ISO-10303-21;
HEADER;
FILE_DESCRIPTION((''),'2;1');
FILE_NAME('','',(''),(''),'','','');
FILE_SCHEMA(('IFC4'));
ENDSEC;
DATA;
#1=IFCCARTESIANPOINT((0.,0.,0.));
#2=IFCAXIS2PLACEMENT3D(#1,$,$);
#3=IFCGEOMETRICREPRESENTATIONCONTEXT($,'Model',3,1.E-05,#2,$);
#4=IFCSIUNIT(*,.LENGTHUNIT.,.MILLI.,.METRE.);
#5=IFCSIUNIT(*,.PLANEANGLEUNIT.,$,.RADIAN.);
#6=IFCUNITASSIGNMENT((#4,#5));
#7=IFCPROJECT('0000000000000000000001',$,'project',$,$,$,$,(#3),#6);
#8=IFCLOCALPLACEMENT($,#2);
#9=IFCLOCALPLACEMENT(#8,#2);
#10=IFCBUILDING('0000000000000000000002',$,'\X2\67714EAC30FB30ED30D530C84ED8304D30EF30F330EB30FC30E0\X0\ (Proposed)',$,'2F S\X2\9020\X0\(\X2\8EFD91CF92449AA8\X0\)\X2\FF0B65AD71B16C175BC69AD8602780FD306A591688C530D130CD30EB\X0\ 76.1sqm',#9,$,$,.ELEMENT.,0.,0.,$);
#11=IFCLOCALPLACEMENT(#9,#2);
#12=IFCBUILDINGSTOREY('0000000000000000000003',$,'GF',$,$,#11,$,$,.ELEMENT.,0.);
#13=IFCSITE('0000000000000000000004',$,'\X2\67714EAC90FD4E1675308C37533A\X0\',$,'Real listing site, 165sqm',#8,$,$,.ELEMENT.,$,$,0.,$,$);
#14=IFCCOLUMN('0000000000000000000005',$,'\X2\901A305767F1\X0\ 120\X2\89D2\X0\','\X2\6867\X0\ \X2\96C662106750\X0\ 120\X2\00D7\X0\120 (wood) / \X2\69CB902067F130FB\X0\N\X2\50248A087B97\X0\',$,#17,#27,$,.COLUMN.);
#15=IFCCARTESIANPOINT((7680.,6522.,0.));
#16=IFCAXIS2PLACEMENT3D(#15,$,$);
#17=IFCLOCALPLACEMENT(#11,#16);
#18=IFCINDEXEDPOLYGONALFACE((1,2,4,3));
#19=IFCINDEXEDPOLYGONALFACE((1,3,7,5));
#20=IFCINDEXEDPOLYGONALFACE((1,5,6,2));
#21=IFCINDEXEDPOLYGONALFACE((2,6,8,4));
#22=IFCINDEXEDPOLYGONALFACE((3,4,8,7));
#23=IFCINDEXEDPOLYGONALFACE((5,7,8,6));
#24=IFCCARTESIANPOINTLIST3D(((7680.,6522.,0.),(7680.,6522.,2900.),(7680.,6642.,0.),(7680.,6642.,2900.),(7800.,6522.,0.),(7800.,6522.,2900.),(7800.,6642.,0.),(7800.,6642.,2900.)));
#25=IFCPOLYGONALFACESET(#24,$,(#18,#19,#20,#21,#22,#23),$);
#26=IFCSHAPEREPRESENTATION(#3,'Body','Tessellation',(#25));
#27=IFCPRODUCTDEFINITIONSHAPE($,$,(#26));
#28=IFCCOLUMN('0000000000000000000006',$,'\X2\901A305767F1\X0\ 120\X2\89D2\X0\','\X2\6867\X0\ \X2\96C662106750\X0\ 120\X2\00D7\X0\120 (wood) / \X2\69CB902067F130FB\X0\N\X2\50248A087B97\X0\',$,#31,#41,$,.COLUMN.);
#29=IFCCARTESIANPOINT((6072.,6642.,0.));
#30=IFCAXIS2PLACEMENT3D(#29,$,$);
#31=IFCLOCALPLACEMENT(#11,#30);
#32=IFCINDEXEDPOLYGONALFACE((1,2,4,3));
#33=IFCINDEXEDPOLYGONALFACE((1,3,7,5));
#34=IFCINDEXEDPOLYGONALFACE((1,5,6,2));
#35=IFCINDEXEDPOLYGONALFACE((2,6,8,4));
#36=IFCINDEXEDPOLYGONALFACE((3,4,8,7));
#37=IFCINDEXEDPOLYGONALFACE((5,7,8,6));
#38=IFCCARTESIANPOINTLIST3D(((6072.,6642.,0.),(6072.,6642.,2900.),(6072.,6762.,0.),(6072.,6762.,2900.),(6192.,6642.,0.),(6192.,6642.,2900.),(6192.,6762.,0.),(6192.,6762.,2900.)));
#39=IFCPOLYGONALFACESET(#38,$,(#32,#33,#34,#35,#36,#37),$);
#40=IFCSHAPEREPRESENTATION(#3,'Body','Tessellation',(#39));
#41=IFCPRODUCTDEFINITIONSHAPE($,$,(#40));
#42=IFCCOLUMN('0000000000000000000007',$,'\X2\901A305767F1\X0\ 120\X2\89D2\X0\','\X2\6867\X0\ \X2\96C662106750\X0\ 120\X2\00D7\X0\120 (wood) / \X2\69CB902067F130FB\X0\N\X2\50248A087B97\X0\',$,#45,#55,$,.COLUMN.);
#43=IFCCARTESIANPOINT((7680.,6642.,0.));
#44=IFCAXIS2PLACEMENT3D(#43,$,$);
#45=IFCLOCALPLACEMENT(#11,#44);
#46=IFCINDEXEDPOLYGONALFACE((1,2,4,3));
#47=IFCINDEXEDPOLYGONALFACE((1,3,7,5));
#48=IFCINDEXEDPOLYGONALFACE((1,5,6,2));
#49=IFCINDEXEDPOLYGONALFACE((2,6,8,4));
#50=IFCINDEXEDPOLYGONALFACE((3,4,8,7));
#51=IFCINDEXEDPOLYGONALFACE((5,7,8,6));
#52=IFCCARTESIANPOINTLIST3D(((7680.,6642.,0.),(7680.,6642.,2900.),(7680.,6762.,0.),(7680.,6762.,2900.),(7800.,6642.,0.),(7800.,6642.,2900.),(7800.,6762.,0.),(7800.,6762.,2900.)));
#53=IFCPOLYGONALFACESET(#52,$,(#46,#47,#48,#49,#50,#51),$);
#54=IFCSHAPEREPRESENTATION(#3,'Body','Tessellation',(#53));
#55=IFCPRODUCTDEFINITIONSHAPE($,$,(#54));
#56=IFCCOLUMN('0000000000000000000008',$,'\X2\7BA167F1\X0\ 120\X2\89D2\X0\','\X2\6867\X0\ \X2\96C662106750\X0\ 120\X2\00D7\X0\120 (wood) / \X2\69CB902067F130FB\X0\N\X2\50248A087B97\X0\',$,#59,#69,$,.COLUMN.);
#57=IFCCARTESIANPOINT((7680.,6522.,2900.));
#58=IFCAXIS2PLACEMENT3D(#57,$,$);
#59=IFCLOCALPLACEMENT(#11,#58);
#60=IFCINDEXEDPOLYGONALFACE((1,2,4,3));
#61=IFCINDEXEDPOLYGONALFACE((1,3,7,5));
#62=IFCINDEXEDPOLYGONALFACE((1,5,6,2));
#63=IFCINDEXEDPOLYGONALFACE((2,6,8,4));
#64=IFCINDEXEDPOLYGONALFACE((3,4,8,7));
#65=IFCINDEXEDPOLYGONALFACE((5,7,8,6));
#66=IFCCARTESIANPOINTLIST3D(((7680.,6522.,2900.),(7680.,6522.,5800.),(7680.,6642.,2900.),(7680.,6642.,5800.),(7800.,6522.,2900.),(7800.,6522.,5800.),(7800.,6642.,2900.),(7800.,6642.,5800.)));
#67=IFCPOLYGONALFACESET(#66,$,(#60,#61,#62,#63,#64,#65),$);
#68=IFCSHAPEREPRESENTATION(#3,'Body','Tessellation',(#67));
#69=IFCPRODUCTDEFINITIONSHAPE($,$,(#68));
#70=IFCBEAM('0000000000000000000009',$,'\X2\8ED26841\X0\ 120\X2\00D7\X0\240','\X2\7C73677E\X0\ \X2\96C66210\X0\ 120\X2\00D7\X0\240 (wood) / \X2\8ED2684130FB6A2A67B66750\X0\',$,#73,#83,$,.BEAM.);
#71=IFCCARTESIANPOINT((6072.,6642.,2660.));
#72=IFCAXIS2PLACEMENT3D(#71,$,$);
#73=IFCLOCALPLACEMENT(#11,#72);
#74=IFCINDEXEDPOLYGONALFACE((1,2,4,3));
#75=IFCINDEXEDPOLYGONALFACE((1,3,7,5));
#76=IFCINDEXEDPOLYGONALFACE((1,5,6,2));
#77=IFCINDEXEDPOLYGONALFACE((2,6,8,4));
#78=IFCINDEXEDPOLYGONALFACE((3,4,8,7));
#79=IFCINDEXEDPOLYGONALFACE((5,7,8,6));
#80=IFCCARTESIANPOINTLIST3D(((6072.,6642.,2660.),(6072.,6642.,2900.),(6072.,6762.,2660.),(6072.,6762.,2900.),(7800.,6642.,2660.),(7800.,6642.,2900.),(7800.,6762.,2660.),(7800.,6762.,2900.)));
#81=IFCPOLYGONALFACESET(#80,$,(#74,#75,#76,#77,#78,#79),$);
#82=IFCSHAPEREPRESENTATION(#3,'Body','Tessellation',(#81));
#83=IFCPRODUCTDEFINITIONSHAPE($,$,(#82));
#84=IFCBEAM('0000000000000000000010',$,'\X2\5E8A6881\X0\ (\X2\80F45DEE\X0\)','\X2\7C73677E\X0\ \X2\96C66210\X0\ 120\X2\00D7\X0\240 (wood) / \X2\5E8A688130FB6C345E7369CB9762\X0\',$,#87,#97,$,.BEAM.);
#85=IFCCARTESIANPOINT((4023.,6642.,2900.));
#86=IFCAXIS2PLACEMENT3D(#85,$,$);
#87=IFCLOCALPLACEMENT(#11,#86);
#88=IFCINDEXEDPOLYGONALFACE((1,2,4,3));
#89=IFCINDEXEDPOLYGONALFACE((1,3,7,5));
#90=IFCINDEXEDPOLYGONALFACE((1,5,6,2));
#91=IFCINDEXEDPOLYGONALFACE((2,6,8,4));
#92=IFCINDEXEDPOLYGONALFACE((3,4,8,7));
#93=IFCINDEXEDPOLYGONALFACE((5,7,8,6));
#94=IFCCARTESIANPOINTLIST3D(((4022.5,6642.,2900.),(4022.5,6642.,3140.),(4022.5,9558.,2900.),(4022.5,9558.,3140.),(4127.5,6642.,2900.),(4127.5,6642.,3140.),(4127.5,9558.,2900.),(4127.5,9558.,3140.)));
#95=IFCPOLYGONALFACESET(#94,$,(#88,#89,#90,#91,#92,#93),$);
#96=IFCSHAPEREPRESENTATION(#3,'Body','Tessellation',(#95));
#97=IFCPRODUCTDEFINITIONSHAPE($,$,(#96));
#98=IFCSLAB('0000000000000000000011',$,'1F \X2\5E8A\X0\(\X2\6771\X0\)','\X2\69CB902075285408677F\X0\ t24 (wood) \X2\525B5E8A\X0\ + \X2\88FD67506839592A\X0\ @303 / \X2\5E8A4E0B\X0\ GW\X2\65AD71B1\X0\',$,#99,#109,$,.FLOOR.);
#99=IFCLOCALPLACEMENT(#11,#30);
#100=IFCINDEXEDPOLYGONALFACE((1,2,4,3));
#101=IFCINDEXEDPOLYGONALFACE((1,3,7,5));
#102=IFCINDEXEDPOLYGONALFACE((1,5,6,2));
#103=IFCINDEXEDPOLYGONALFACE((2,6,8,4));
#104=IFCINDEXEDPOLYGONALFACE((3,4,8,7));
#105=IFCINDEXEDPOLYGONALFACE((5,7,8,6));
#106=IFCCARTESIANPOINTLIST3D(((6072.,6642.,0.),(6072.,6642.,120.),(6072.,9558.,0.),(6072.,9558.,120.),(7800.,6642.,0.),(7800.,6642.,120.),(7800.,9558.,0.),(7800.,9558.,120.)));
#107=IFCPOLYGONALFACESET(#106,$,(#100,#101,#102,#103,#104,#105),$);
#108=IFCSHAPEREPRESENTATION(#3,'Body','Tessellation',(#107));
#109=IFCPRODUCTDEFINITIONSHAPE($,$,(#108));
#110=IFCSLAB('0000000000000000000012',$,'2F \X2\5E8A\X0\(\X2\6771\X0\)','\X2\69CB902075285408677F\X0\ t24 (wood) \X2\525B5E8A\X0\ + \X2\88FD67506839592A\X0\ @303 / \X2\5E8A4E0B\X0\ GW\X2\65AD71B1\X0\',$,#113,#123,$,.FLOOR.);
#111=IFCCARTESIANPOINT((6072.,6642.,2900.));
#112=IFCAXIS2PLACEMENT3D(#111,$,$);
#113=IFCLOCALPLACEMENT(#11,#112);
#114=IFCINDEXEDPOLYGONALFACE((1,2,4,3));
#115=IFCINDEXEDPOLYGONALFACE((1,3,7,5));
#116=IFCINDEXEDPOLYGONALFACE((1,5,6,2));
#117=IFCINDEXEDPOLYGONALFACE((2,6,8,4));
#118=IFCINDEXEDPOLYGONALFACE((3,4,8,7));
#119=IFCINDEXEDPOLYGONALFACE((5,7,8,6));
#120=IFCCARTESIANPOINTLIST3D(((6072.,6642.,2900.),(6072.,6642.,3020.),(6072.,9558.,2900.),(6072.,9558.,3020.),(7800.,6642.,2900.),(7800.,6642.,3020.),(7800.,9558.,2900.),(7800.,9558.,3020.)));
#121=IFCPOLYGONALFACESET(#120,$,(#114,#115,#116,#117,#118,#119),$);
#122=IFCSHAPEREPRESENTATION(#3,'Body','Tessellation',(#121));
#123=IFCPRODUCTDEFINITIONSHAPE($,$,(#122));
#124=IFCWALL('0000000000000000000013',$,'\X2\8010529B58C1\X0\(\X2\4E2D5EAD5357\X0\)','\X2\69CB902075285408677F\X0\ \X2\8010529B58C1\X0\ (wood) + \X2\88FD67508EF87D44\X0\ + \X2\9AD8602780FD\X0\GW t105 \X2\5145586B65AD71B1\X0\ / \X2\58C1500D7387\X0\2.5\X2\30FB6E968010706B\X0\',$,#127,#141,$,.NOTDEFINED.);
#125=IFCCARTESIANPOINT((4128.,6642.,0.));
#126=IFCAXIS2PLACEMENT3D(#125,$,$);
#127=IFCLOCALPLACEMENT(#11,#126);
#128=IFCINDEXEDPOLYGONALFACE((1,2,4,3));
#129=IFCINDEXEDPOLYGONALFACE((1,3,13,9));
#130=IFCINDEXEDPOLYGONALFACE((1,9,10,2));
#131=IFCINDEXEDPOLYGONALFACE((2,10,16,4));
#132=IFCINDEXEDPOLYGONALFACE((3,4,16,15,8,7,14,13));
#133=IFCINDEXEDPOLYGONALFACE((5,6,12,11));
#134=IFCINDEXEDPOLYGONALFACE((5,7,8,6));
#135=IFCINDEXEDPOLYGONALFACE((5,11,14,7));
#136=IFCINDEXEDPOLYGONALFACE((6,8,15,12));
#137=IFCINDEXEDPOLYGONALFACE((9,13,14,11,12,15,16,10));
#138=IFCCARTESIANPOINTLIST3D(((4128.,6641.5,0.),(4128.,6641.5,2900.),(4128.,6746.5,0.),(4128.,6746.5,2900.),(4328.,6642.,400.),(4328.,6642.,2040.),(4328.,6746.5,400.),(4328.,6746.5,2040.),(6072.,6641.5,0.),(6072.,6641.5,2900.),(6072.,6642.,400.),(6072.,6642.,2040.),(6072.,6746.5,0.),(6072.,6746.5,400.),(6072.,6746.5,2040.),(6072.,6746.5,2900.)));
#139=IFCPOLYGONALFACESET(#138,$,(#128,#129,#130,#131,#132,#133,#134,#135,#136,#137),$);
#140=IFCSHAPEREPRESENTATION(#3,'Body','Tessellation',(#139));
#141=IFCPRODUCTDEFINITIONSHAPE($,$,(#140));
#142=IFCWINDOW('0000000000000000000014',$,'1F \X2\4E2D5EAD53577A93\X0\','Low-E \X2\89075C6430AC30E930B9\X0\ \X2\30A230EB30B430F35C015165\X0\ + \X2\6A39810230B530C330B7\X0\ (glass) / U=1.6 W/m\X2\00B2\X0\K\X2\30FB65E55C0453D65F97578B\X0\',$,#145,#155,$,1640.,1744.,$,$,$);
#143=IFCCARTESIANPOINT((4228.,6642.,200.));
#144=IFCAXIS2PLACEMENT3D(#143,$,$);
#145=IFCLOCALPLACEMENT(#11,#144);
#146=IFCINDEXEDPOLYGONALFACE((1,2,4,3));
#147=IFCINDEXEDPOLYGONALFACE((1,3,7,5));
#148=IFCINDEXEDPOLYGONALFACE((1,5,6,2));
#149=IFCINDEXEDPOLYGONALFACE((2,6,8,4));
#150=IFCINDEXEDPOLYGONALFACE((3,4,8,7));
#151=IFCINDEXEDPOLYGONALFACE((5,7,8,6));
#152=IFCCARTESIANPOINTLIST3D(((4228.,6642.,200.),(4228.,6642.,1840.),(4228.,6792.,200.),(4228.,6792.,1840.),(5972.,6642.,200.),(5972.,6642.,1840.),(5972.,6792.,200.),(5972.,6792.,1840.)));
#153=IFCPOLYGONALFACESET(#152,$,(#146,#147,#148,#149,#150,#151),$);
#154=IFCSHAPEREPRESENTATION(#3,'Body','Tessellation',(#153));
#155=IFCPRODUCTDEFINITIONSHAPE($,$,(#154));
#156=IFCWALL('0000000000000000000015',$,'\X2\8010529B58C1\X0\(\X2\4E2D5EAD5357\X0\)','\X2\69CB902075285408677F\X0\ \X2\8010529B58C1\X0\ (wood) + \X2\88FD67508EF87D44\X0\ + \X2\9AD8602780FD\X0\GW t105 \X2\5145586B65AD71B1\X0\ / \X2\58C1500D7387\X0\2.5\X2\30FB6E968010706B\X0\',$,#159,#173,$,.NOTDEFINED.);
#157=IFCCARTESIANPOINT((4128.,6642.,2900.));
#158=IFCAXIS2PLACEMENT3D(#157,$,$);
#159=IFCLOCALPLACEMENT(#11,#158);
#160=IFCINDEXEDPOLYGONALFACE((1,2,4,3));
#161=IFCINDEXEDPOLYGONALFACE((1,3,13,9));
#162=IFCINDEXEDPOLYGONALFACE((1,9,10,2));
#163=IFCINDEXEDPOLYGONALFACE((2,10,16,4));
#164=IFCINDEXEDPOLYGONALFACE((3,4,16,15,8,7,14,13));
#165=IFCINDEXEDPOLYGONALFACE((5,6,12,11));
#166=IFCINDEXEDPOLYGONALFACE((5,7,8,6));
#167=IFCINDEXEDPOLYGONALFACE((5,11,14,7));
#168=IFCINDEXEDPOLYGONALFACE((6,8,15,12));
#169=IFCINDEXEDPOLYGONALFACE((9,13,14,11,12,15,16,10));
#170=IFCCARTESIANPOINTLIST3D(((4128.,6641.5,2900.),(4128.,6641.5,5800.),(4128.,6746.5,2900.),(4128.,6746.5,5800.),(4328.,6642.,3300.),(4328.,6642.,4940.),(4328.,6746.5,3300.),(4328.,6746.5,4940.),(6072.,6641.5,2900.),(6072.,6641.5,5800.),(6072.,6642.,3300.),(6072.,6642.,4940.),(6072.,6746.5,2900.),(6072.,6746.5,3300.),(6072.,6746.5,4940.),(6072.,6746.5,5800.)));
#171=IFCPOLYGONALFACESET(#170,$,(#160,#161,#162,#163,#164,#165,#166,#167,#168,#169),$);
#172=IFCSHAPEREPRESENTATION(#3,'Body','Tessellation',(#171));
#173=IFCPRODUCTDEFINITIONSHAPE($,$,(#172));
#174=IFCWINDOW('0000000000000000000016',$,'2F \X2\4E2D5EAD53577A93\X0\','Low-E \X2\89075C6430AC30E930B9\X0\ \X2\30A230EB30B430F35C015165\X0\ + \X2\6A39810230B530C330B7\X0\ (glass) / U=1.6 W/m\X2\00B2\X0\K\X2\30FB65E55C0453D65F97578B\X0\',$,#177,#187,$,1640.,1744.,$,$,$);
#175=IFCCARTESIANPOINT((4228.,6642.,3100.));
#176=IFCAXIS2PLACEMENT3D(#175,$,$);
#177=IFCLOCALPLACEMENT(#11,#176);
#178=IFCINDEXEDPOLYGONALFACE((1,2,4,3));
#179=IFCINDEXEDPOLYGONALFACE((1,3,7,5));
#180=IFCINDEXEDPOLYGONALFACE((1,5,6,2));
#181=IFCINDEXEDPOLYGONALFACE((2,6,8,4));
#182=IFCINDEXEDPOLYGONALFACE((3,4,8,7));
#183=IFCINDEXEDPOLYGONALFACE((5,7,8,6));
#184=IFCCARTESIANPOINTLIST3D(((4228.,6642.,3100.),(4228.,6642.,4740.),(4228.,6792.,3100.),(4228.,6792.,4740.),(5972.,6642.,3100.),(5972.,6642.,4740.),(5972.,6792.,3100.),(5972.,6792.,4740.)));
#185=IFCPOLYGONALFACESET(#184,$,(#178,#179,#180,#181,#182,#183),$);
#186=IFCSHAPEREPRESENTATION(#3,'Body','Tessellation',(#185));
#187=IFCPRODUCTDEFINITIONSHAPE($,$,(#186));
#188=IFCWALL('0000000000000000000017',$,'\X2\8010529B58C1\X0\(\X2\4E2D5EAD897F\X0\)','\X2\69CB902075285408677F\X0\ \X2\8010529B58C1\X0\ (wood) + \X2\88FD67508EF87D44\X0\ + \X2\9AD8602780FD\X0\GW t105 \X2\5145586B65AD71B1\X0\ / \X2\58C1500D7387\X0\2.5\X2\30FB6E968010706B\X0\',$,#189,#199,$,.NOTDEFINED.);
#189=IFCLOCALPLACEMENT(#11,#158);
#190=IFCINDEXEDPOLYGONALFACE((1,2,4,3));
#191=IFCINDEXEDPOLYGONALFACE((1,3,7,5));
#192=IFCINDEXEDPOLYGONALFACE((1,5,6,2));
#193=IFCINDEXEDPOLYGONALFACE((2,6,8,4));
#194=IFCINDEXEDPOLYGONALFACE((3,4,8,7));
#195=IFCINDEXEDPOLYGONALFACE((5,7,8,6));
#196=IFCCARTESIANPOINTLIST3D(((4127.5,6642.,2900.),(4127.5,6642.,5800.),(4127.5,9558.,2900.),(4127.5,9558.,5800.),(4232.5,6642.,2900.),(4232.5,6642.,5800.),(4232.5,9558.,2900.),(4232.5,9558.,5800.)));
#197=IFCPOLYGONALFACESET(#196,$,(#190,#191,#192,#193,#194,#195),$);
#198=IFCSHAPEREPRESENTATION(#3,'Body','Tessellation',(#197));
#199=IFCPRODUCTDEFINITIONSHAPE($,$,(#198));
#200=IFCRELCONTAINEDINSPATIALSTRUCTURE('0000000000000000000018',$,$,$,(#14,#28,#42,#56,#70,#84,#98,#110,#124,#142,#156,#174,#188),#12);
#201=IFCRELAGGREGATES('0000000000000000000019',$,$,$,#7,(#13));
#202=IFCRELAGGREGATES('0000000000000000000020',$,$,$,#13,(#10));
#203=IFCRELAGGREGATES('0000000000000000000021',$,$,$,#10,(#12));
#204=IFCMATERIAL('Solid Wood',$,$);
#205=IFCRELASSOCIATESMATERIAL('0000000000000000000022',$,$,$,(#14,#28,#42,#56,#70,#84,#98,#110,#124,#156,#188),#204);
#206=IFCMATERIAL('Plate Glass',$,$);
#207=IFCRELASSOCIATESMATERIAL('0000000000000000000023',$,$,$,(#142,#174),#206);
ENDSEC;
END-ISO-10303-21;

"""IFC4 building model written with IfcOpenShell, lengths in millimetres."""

from ifc_helpers import new_model, si_unit, frame, frame_2d, origin, place, context, project, spatial, rectangle, extrude, material, element, fill, save


model = new_model("IFC4")

# Units and contexts
model_context = context("Model", 3, precision=1e-05, world=origin())
ifc_project = project(units=[si_unit("LENGTHUNIT", "METRE", prefix="MILLI"), si_unit("PLANEANGLEUNIT", "RADIAN")], contexts=[model_context])

# Site, building, storey
site_placement = place(None, origin())
site = spatial("IfcSite", under=ifc_project, at=site_placement, Name="東京都世田谷区", ObjectType="Real listing site, 165sqm", CompositionType="ELEMENT", RefElevation=0.0)
building_placement = place(site_placement, origin())
building = spatial("IfcBuilding", under=site, at=building_placement, Name="東京・ロフト付きワンルーム (Proposed)", ObjectType="2F S造(軽量鉄骨)＋断熱気密高性能な外装パネル 76.1sqm", CompositionType="ELEMENT", ElevationOfRefHeight=0.0, ElevationOfTerrain=0.0)
storey_placement = place(building_placement, origin())
storey = spatial("IfcBuildingStorey", under=building, at=storey_placement, Name="GF", CompositionType="ELEMENT", Elevation=0.0)

# Columns
ifc_material_1 = material(Name="Solid Wood")
column_1_placement = place(storey_placement, frame((7680.0, 6522.0, 0.0)))
element("IfcColumn", 1, at=column_1_placement, inside=storey, material=ifc_material_1, Name="通し柱 120角", Description="桧 集成材 120×120 (wood) / 構造柱・N値計算", PredefinedType="COLUMN", context=model_context, shape_type="SweptSolid", body=[
    extrude(rectangle(XDim=120.0, YDim=120.0, at=frame_2d((60.0, 60.0))), frame((7680.0, 6522.0, 0.0)), (0.0, 0.0, 1.0), 2900.0),
])
column_2_placement = place(storey_placement, frame((6072.0, 6642.0, 0.0)))
element("IfcColumn", 2, at=column_2_placement, inside=storey, material=ifc_material_1, Name="通し柱 120角", Description="桧 集成材 120×120 (wood) / 構造柱・N値計算", PredefinedType="COLUMN", context=model_context, shape_type="SweptSolid", body=[
    extrude(rectangle(XDim=120.0, YDim=120.0, at=frame_2d((60.0, 60.0))), frame((6072.0, 6642.0, 0.0)), (0.0, 0.0, 1.0), 2900.0),
])
column_3_placement = place(storey_placement, frame((7680.0, 6642.0, 0.0)))
element("IfcColumn", 3, at=column_3_placement, inside=storey, material=ifc_material_1, Name="通し柱 120角", Description="桧 集成材 120×120 (wood) / 構造柱・N値計算", PredefinedType="COLUMN", context=model_context, shape_type="SweptSolid", body=[
    extrude(rectangle(XDim=120.0, YDim=120.0, at=frame_2d((60.0, 60.0))), frame((7680.0, 6642.0, 0.0)), (0.0, 0.0, 1.0), 2900.0),
])
column_4_placement = place(storey_placement, frame((7680.0, 6522.0, 2900.0)))
element("IfcColumn", 4, at=column_4_placement, inside=storey, material=ifc_material_1, Name="管柱 120角", Description="桧 集成材 120×120 (wood) / 構造柱・N値計算", PredefinedType="COLUMN", context=model_context, shape_type="SweptSolid", body=[
    extrude(rectangle(XDim=120.0, YDim=120.0, at=frame_2d((60.0, 60.0))), frame((7680.0, 6522.0, 2900.0)), (0.0, 0.0, 1.0), 2900.0),
])

# Beams
beam_1_placement = place(storey_placement, frame((6072.0, 6642.0, 2660.0)))
element("IfcBeam", 5, at=beam_1_placement, inside=storey, material=ifc_material_1, Name="軒桁 120×240", Description="米松 集成 120×240 (wood) / 軒桁・横架材", PredefinedType="BEAM", context=model_context, shape_type="SweptSolid", body=[
    extrude(rectangle(XDim=1728.0, YDim=120.0, at=frame_2d((864.0, 60.0))), frame((6072.0, 6642.0, 2660.0)), (0.0, 0.0, 1.0), 240.0),
])
beam_2_placement = place(storey_placement, frame((4023.0, 6642.0, 2900.0)))
element("IfcBeam", 6, at=beam_2_placement, inside=storey, material=ifc_material_1, Name="床梁 (胴差)", Description="米松 集成 120×240 (wood) / 床梁・水平構面", PredefinedType="BEAM", context=model_context, shape_type="SweptSolid", body=[
    extrude(rectangle(XDim=105.0, YDim=2916.0, at=frame_2d((52.0, 1458.0))), frame((4023.0, 6642.0, 2900.0)), (0.0, 0.0, 1.0), 240.0),
])

# Slabs
slab_1_placement = place(storey_placement, frame((6072.0, 6642.0, 0.0)))
element("IfcSlab", 7, at=slab_1_placement, inside=storey, material=ifc_material_1, Name="1F 床(東)", Description="構造用合板 t24 (wood) 剛床 + 製材根太 @303 / 床下 GW断熱", PredefinedType="FLOOR", context=model_context, shape_type="SweptSolid", body=[
    extrude(rectangle(XDim=1728.0, YDim=2916.0, at=frame_2d((864.0, 1458.0))), frame((6072.0, 6642.0, 0.0)), (0.0, 0.0, 1.0), 120.0),
])
slab_2_placement = place(storey_placement, frame((6072.0, 6642.0, 2900.0)))
element("IfcSlab", 8, at=slab_2_placement, inside=storey, material=ifc_material_1, Name="2F 床(東)", Description="構造用合板 t24 (wood) 剛床 + 製材根太 @303 / 床下 GW断熱", PredefinedType="FLOOR", context=model_context, shape_type="SweptSolid", body=[
    extrude(rectangle(XDim=1728.0, YDim=2916.0, at=frame_2d((864.0, 1458.0))), frame((6072.0, 6642.0, 2900.0)), (0.0, 0.0, 1.0), 120.0),
])

# Wall, opening, window
wall_1_placement = place(storey_placement, frame((4128.0, 6642.0, 0.0)))
wall_1 = element("IfcWall", 9, at=wall_1_placement, inside=storey, material=ifc_material_1, Name="耐力壁(中庭南)", Description="構造用合板 耐力壁 (wood) + 製材軸組 + 高性能GW t105 充填断熱 / 壁倍率2.5・準耐火", PredefinedType="NOTDEFINED", context=model_context, shape_type="SweptSolid", body=[
    extrude(rectangle(XDim=1944.0, YDim=105.0, at=frame_2d((972.0, 52.0))), frame((4128.0, 6642.0, 0.0)), (0.0, 0.0, 1.0), 2900.0),
])
opening_1_placement = place(storey_placement, frame((4228.0, 6642.0, 200.0)))
opening_1 = element("IfcOpeningElement", 10, at=opening_1_placement, cuts=wall_1, PredefinedType="NOTDEFINED", context=model_context, shape_type="SweptSolid", body=[
    extrude(rectangle(XDim=1744.0, YDim=150.0, at=frame_2d((872.0, 75.0))), frame((4228.0, 6642.0, 200.0)), (0.0, 0.0, 1.0), 1640.0),
])
ifc_material_2 = material(Name="Plate Glass")
window_1_placement = place(storey_placement, frame((4228.0, 6642.0, 200.0)))
window_1 = element("IfcWindow", 11, at=window_1_placement, inside=storey, material=ifc_material_2, Name="1F 中庭南窓", Description="Low-E 複層ガラス アルゴン封入 + 樹脂サッシ (glass) / U=1.6 W/m²K・日射取得型", OverallHeight=1640.0, OverallWidth=1744.0, context=model_context, shape_type="SweptSolid", body=[
    extrude(rectangle(XDim=1744.0, YDim=150.0, at=frame_2d((872.0, 75.0))), frame((4228.0, 6642.0, 200.0)), (0.0, 0.0, 1.0), 1640.0),
])
fill(opening_1, window_1)

# Wall, opening, window
wall_2_placement = place(storey_placement, frame((4128.0, 6642.0, 2900.0)))
wall_2 = element("IfcWall", 12, at=wall_2_placement, inside=storey, material=ifc_material_1, Name="耐力壁(中庭南)", Description="構造用合板 耐力壁 (wood) + 製材軸組 + 高性能GW t105 充填断熱 / 壁倍率2.5・準耐火", PredefinedType="NOTDEFINED", context=model_context, shape_type="SweptSolid", body=[
    extrude(rectangle(XDim=1944.0, YDim=105.0, at=frame_2d((972.0, 52.0))), frame((4128.0, 6642.0, 2900.0)), (0.0, 0.0, 1.0), 2900.0),
])
opening_2_placement = place(storey_placement, frame((4228.0, 6642.0, 3100.0)))
opening_2 = element("IfcOpeningElement", 13, at=opening_2_placement, cuts=wall_2, PredefinedType="NOTDEFINED", context=model_context, shape_type="SweptSolid", body=[
    extrude(rectangle(XDim=1744.0, YDim=150.0, at=frame_2d((872.0, 75.0))), frame((4228.0, 6642.0, 3100.0)), (0.0, 0.0, 1.0), 1640.0),
])
window_2_placement = place(storey_placement, frame((4228.0, 6642.0, 3100.0)))
window_2 = element("IfcWindow", 14, at=window_2_placement, inside=storey, material=ifc_material_2, Name="2F 中庭南窓", Description="Low-E 複層ガラス アルゴン封入 + 樹脂サッシ (glass) / U=1.6 W/m²K・日射取得型", OverallHeight=1640.0, OverallWidth=1744.0, context=model_context, shape_type="SweptSolid", body=[
    extrude(rectangle(XDim=1744.0, YDim=150.0, at=frame_2d((872.0, 75.0))), frame((4228.0, 6642.0, 3100.0)), (0.0, 0.0, 1.0), 1640.0),
])
fill(opening_2, window_2)

# Wall
wall_3_placement = place(storey_placement, frame((4128.0, 6642.0, 2900.0)))
element("IfcWall", 15, at=wall_3_placement, inside=storey, material=ifc_material_1, Name="耐力壁(中庭西)", Description="構造用合板 耐力壁 (wood) + 製材軸組 + 高性能GW t105 充填断熱 / 壁倍率2.5・準耐火", PredefinedType="NOTDEFINED", context=model_context, shape_type="SweptSolid", body=[
    extrude(rectangle(XDim=105.0, YDim=2916.0, at=frame_2d((52.0, 1458.0))), frame((4128.0, 6642.0, 2900.0)), (0.0, 0.0, 1.0), 2900.0),
])

save(model, "model.ifc")
